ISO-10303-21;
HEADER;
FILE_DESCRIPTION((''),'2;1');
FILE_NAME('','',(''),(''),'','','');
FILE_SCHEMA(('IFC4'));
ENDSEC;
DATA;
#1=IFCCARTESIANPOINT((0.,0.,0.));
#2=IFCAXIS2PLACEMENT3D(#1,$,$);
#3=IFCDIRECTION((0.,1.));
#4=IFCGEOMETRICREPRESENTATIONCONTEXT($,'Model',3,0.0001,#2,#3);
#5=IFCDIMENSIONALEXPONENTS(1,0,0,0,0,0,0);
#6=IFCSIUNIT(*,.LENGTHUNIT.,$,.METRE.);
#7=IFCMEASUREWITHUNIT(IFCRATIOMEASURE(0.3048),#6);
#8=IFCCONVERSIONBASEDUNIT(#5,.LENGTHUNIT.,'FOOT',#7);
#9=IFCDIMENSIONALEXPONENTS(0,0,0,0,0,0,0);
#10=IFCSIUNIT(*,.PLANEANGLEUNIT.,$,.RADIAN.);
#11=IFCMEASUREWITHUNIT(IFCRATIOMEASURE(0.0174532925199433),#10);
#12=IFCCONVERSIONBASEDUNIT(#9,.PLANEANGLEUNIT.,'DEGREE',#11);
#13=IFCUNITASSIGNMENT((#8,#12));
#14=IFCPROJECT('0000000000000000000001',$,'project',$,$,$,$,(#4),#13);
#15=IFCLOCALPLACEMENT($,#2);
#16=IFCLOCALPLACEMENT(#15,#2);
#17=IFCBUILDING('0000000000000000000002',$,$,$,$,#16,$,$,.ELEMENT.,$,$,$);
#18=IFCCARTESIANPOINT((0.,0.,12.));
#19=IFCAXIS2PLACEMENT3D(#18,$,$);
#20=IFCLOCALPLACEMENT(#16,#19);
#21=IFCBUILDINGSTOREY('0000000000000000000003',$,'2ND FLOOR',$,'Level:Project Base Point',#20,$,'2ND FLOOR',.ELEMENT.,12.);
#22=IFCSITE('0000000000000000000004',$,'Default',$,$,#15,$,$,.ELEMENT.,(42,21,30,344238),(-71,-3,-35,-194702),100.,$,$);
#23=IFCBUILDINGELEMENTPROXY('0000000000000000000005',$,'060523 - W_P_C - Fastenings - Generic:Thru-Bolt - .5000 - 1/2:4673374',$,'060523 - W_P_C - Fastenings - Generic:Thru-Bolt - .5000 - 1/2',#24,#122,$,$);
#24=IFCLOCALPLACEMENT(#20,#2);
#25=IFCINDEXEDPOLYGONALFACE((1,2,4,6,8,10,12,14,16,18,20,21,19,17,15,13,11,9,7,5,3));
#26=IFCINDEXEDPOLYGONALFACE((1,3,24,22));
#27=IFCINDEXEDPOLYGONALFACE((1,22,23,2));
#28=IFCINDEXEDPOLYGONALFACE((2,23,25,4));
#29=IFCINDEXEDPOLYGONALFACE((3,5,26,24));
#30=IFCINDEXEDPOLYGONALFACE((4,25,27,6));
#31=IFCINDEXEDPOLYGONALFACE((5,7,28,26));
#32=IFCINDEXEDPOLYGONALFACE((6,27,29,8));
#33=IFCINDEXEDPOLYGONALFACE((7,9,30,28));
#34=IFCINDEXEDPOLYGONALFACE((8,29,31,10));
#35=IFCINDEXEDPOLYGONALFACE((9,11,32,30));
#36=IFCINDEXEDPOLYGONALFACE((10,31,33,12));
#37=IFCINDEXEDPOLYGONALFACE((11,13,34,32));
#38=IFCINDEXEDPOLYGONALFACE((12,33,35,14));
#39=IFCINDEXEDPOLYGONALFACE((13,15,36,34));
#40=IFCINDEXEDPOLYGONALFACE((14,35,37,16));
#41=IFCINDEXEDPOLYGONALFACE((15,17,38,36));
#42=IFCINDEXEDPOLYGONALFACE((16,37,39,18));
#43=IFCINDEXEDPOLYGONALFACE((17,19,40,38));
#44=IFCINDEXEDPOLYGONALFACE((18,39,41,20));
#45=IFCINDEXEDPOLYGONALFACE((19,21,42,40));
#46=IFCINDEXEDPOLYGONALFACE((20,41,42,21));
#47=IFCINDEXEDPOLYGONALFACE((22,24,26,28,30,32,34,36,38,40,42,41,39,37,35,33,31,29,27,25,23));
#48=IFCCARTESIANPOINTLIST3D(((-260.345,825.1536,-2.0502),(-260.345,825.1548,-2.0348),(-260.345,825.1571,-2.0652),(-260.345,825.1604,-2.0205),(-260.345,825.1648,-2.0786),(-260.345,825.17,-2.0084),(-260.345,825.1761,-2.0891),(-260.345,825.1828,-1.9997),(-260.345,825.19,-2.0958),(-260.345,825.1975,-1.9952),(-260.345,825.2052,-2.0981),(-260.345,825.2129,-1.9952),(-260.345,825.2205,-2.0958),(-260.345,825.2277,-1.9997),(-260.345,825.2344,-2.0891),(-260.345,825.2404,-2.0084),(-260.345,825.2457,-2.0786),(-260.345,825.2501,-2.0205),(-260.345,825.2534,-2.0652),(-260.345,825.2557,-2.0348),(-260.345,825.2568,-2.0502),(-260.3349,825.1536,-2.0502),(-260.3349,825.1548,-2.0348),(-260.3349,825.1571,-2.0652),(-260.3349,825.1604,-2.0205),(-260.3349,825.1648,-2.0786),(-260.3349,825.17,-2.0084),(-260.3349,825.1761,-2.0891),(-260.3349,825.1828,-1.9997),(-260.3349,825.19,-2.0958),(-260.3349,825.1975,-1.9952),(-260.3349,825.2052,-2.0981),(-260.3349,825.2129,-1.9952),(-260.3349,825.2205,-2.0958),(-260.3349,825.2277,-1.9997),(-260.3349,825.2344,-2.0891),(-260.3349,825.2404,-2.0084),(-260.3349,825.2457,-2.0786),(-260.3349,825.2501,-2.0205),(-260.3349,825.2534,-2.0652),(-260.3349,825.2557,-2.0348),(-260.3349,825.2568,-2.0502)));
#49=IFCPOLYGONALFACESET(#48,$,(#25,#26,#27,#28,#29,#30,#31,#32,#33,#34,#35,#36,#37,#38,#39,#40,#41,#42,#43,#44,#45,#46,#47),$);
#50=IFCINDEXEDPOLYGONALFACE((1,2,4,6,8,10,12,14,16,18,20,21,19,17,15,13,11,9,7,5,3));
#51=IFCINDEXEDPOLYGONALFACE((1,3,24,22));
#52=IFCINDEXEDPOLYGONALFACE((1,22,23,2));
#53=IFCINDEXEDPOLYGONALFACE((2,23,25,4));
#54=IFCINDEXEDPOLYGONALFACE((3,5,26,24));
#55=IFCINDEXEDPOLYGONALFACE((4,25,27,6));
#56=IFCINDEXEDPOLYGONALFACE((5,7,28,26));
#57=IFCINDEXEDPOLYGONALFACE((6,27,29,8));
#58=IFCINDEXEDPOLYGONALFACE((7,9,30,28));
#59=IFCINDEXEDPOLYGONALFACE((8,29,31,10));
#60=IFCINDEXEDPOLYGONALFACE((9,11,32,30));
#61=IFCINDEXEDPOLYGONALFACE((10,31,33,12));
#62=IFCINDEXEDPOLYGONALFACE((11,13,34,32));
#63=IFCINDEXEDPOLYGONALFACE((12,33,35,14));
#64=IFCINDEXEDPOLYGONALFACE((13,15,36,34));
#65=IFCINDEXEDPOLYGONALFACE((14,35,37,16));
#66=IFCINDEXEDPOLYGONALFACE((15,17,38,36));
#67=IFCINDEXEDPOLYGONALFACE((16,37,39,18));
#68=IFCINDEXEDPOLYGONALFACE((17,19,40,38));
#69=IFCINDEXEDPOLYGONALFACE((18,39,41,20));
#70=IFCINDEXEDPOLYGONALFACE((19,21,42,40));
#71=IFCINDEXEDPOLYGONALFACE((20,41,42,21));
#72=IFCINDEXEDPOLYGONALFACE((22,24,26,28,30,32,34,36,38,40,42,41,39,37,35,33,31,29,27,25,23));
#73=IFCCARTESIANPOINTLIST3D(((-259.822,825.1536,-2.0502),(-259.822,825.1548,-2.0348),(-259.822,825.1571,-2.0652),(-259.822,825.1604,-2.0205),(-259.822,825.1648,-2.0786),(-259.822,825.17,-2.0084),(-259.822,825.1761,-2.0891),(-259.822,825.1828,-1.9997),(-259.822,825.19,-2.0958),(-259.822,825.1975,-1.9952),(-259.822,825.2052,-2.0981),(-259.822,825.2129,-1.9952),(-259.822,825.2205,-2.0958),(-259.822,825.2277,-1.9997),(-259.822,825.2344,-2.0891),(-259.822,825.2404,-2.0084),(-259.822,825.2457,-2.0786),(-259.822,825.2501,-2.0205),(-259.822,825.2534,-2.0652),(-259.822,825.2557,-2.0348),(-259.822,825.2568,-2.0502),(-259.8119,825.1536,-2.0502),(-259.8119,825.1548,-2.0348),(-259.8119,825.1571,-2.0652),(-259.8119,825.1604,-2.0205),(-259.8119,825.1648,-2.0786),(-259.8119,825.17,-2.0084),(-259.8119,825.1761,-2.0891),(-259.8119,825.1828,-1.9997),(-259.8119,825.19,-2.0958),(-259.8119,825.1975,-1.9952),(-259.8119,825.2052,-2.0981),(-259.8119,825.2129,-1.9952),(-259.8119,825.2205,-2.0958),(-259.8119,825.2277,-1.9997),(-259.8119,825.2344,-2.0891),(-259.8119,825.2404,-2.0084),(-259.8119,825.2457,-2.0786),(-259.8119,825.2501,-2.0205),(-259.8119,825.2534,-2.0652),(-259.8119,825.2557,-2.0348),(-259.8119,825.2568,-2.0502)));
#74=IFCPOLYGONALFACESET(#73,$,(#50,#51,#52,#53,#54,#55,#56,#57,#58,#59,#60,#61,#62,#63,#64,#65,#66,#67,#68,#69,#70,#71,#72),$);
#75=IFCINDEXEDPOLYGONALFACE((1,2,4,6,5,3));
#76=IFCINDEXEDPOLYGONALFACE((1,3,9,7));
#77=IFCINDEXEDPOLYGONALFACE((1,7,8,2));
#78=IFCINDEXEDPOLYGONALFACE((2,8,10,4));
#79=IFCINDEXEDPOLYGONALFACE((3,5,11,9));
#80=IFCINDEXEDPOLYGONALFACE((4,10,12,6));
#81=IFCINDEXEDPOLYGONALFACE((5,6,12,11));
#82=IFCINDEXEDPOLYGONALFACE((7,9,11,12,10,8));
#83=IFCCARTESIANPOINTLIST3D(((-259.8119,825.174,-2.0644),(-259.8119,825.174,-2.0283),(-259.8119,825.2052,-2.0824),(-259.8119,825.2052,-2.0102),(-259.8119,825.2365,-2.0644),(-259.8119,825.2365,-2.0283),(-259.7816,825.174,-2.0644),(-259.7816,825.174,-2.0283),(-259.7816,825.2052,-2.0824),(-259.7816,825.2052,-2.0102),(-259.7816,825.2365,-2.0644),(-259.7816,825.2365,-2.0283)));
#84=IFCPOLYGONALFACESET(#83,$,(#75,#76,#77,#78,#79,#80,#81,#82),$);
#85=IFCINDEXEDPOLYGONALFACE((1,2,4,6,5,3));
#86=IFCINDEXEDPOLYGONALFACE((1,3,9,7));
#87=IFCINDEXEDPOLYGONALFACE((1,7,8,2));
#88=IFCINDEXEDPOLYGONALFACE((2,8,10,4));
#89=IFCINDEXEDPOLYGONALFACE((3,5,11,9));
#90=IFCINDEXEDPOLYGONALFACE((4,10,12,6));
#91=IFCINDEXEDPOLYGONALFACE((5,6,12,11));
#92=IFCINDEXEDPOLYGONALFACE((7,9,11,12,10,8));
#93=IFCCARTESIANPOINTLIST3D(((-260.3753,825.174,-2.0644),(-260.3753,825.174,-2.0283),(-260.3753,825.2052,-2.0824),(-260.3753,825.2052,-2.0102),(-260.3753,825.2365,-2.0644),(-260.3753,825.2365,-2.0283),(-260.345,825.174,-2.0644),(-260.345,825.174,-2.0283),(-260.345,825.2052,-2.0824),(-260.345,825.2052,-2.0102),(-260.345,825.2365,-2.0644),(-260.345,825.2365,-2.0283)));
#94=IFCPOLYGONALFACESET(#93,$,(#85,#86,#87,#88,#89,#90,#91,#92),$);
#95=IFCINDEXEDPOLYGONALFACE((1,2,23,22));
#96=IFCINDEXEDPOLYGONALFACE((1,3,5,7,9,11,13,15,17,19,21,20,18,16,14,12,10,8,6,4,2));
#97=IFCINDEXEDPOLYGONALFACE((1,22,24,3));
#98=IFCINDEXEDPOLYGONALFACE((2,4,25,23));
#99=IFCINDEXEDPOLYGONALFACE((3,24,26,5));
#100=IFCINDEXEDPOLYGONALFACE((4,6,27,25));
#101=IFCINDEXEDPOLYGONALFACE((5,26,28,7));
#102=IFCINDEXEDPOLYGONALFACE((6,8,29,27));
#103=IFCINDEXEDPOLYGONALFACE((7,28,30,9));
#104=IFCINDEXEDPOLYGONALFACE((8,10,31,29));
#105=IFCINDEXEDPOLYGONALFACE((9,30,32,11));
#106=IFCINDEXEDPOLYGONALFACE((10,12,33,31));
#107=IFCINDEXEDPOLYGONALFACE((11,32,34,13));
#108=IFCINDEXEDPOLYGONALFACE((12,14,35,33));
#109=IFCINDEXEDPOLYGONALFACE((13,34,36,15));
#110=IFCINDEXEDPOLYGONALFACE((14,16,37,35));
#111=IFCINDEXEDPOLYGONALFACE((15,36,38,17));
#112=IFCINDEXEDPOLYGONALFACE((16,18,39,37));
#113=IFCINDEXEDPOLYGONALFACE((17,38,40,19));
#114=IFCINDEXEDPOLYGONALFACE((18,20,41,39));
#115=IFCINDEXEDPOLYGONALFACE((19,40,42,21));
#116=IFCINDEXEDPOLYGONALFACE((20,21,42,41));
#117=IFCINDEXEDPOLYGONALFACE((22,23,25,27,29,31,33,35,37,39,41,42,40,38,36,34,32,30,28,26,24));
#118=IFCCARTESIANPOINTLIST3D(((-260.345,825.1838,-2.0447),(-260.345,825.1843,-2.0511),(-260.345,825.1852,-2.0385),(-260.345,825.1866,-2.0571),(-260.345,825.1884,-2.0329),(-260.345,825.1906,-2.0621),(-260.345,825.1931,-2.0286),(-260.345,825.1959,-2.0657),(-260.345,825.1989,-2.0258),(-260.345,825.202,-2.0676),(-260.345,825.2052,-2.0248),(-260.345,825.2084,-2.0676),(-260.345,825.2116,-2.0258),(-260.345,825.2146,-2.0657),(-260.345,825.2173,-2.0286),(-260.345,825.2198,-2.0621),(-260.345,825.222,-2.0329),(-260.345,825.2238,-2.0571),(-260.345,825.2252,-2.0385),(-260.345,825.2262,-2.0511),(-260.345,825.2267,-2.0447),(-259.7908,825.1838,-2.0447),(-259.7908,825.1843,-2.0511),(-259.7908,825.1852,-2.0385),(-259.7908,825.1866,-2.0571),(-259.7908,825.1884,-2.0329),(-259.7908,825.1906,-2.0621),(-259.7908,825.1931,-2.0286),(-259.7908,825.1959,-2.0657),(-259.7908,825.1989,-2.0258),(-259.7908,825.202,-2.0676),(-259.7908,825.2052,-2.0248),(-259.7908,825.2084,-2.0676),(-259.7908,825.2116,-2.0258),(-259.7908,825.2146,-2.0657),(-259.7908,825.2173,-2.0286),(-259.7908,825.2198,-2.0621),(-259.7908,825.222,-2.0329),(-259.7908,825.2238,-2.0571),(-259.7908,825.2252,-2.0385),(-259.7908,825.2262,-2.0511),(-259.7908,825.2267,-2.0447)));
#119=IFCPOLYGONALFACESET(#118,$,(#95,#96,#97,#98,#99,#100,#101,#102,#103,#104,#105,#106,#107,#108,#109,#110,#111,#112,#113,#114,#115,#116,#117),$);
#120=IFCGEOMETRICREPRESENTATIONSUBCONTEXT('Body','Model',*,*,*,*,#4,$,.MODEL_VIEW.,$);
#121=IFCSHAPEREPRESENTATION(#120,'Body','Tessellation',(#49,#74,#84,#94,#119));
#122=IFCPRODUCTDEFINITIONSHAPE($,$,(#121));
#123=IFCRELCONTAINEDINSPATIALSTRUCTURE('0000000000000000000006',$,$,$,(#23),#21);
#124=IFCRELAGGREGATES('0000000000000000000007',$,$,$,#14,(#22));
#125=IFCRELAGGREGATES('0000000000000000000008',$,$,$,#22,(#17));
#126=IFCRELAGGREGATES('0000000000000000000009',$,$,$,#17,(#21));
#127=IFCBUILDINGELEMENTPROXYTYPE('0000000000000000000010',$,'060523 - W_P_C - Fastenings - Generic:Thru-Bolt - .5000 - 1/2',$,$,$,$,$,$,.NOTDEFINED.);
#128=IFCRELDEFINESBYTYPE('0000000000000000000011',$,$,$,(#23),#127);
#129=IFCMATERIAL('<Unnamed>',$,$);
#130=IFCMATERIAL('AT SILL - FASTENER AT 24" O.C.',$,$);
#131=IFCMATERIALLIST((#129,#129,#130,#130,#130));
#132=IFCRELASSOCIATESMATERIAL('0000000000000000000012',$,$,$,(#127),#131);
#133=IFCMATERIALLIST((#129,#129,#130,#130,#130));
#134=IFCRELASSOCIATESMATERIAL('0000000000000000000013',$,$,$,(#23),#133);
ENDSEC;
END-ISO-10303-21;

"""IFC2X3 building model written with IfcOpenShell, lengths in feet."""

from ifc_helpers import new_model, entity, si_unit, converted_unit, direction, frame, frame_2d, origin, place, context, subcontext, project, spatial, polyline, circle, outline, extrude, source, transform, mapped, material, material_list, type_object, type_shapes, element, save


model = new_model("IFC2X3")

# Units and contexts
model_context = context("Model", 3, precision=0.0001, world=origin(), true_north=direction((0.0, 1.0)))
body_context = subcontext(model_context, "Body", "Model", "MODEL_VIEW")
ifc_project = project(units=[converted_unit("LENGTHUNIT", "FOOT", entity("IfcRatioMeasure", 0.3048), si_unit("LENGTHUNIT", "METRE"), dimensions=[1, 0, 0, 0, 0, 0, 0]), converted_unit("PLANEANGLEUNIT", "DEGREE", entity("IfcRatioMeasure", 0.0174532925199433), si_unit("PLANEANGLEUNIT", "RADIAN"), dimensions=[0, 0, 0, 0, 0, 0, 0])], contexts=[model_context])

# Site, building, storey
site_placement = place(None, origin())
site = spatial("IfcSite", under=ifc_project, at=site_placement, Name="Default", CompositionType="ELEMENT", RefLatitude=(42, 21, 30, 344238), RefLongitude=(-71, -3, -35, -194702), RefElevation=100.0)
building_placement = place(site_placement, origin())
building = spatial("IfcBuilding", under=site, at=building_placement, CompositionType="ELEMENT")
storey_placement = place(building_placement, frame((0.0, 0.0, 12.0)))
storey = spatial("IfcBuildingStorey", under=building, at=storey_placement, Name="2ND FLOOR", ObjectType="Level:Project Base Point", LongName="2ND FLOOR", CompositionType="ELEMENT", Elevation=12.0)

# Building element proxy
ifc_material_1 = material(Name="<Unnamed>")
ifc_material_2 = material(Name="AT SILL - FASTENER AT 24\" O.C.")
ifc_material_list_1 = material_list([ifc_material_1, ifc_material_1, ifc_material_2, ifc_material_2, ifc_material_2])
ifc_material_list_2 = material_list([ifc_material_1, ifc_material_1, ifc_material_2, ifc_material_2, ifc_material_2])
building_element_proxy_type_1 = type_object("IfcBuildingElementProxyType", Name="060523 - W_P_C - Fastenings - Generic:Thru-Bolt - .5000 - 1/2", PredefinedType="NOTDEFINED", material=ifc_material_list_2)
shared_shape_1 = source(origin(), body_context, "Body", "SweptSolid", [
    extrude(circle(Radius=0.0518, at=frame_2d((0.0, 0.0), x_axis=(1.0, 0.0))), frame((0.0, 0.0, 0.0), z_axis=(0.0, 0.0, 1.0), x_axis=(0.0, -1.0, 0.0)), (0.0, 0.0, 1.0), 0.0101),
    extrude(circle(Radius=0.0518, at=frame_2d((0.0, 0.0), x_axis=(1.0, 0.0))), frame((0.0, 0.0, -0.523), z_axis=(0.0, 0.0, 1.0), x_axis=(0.0, -1.0, 0.0)), (0.0, 0.0, 1.0), 0.0101),
    extrude(outline(polyline([(-0.018, -0.0313), (0.018, -0.0313), (0.0361, 0.0), (0.018, 0.0312), (-0.018, 0.0312), (-0.0361, 0.0), (-0.018, -0.0313)])), frame((0.0, 0.0, -0.5533), z_axis=(0.0, 0.0, 1.0), x_axis=(0.866025, -0.5, 0.0)), (0.0, 0.0, 1.0), 0.0303),
    extrude(outline(polyline([(-0.018, -0.0313), (0.018, -0.0313), (0.0361, 0.0), (0.018, 0.0313), (-0.018, 0.0313), (-0.0361, 0.0), (-0.018, -0.0313)])), frame((0.0, 0.0, 0.0101), z_axis=(0.0, 0.0, 1.0), x_axis=(0.0, -1.0, 0.0)), (0.0, 0.0, 1.0), 0.0303),
    extrude(circle(Radius=0.0215, at=frame_2d((0.0, 0.0), x_axis=(1.0, 0.0))), frame((0.0, 0.0, -0.5442), z_axis=(0.0, 0.0, 1.0), x_axis=(0.0, 1.0, 0.0)), (0.0, 0.0, 1.0), 0.5543),
])
type_shapes(building_element_proxy_type_1, [shared_shape_1])
proxy_1_placement = place(storey_placement, frame((-260.3349, 825.2052, -2.0463), z_axis=(-1.0, 0.0, 0.0), x_axis=(0.0, -1.0, 0.0)))
element("IfcBuildingElementProxy", 1, at=proxy_1_placement, inside=storey, type_object=building_element_proxy_type_1, material=ifc_material_list_1, Name="060523 - W_P_C - Fastenings - Generic:Thru-Bolt - .5000 - 1/2:4673374", ObjectType="060523 - W_P_C - Fastenings - Generic:Thru-Bolt - .5000 - 1/2", context=body_context, shape_type="MappedRepresentation", body=[
    mapped(shared_shape_1, transform((0.0, 0.0, 0.0), scale=1.0)),
])

save(model, "model.ifc")
